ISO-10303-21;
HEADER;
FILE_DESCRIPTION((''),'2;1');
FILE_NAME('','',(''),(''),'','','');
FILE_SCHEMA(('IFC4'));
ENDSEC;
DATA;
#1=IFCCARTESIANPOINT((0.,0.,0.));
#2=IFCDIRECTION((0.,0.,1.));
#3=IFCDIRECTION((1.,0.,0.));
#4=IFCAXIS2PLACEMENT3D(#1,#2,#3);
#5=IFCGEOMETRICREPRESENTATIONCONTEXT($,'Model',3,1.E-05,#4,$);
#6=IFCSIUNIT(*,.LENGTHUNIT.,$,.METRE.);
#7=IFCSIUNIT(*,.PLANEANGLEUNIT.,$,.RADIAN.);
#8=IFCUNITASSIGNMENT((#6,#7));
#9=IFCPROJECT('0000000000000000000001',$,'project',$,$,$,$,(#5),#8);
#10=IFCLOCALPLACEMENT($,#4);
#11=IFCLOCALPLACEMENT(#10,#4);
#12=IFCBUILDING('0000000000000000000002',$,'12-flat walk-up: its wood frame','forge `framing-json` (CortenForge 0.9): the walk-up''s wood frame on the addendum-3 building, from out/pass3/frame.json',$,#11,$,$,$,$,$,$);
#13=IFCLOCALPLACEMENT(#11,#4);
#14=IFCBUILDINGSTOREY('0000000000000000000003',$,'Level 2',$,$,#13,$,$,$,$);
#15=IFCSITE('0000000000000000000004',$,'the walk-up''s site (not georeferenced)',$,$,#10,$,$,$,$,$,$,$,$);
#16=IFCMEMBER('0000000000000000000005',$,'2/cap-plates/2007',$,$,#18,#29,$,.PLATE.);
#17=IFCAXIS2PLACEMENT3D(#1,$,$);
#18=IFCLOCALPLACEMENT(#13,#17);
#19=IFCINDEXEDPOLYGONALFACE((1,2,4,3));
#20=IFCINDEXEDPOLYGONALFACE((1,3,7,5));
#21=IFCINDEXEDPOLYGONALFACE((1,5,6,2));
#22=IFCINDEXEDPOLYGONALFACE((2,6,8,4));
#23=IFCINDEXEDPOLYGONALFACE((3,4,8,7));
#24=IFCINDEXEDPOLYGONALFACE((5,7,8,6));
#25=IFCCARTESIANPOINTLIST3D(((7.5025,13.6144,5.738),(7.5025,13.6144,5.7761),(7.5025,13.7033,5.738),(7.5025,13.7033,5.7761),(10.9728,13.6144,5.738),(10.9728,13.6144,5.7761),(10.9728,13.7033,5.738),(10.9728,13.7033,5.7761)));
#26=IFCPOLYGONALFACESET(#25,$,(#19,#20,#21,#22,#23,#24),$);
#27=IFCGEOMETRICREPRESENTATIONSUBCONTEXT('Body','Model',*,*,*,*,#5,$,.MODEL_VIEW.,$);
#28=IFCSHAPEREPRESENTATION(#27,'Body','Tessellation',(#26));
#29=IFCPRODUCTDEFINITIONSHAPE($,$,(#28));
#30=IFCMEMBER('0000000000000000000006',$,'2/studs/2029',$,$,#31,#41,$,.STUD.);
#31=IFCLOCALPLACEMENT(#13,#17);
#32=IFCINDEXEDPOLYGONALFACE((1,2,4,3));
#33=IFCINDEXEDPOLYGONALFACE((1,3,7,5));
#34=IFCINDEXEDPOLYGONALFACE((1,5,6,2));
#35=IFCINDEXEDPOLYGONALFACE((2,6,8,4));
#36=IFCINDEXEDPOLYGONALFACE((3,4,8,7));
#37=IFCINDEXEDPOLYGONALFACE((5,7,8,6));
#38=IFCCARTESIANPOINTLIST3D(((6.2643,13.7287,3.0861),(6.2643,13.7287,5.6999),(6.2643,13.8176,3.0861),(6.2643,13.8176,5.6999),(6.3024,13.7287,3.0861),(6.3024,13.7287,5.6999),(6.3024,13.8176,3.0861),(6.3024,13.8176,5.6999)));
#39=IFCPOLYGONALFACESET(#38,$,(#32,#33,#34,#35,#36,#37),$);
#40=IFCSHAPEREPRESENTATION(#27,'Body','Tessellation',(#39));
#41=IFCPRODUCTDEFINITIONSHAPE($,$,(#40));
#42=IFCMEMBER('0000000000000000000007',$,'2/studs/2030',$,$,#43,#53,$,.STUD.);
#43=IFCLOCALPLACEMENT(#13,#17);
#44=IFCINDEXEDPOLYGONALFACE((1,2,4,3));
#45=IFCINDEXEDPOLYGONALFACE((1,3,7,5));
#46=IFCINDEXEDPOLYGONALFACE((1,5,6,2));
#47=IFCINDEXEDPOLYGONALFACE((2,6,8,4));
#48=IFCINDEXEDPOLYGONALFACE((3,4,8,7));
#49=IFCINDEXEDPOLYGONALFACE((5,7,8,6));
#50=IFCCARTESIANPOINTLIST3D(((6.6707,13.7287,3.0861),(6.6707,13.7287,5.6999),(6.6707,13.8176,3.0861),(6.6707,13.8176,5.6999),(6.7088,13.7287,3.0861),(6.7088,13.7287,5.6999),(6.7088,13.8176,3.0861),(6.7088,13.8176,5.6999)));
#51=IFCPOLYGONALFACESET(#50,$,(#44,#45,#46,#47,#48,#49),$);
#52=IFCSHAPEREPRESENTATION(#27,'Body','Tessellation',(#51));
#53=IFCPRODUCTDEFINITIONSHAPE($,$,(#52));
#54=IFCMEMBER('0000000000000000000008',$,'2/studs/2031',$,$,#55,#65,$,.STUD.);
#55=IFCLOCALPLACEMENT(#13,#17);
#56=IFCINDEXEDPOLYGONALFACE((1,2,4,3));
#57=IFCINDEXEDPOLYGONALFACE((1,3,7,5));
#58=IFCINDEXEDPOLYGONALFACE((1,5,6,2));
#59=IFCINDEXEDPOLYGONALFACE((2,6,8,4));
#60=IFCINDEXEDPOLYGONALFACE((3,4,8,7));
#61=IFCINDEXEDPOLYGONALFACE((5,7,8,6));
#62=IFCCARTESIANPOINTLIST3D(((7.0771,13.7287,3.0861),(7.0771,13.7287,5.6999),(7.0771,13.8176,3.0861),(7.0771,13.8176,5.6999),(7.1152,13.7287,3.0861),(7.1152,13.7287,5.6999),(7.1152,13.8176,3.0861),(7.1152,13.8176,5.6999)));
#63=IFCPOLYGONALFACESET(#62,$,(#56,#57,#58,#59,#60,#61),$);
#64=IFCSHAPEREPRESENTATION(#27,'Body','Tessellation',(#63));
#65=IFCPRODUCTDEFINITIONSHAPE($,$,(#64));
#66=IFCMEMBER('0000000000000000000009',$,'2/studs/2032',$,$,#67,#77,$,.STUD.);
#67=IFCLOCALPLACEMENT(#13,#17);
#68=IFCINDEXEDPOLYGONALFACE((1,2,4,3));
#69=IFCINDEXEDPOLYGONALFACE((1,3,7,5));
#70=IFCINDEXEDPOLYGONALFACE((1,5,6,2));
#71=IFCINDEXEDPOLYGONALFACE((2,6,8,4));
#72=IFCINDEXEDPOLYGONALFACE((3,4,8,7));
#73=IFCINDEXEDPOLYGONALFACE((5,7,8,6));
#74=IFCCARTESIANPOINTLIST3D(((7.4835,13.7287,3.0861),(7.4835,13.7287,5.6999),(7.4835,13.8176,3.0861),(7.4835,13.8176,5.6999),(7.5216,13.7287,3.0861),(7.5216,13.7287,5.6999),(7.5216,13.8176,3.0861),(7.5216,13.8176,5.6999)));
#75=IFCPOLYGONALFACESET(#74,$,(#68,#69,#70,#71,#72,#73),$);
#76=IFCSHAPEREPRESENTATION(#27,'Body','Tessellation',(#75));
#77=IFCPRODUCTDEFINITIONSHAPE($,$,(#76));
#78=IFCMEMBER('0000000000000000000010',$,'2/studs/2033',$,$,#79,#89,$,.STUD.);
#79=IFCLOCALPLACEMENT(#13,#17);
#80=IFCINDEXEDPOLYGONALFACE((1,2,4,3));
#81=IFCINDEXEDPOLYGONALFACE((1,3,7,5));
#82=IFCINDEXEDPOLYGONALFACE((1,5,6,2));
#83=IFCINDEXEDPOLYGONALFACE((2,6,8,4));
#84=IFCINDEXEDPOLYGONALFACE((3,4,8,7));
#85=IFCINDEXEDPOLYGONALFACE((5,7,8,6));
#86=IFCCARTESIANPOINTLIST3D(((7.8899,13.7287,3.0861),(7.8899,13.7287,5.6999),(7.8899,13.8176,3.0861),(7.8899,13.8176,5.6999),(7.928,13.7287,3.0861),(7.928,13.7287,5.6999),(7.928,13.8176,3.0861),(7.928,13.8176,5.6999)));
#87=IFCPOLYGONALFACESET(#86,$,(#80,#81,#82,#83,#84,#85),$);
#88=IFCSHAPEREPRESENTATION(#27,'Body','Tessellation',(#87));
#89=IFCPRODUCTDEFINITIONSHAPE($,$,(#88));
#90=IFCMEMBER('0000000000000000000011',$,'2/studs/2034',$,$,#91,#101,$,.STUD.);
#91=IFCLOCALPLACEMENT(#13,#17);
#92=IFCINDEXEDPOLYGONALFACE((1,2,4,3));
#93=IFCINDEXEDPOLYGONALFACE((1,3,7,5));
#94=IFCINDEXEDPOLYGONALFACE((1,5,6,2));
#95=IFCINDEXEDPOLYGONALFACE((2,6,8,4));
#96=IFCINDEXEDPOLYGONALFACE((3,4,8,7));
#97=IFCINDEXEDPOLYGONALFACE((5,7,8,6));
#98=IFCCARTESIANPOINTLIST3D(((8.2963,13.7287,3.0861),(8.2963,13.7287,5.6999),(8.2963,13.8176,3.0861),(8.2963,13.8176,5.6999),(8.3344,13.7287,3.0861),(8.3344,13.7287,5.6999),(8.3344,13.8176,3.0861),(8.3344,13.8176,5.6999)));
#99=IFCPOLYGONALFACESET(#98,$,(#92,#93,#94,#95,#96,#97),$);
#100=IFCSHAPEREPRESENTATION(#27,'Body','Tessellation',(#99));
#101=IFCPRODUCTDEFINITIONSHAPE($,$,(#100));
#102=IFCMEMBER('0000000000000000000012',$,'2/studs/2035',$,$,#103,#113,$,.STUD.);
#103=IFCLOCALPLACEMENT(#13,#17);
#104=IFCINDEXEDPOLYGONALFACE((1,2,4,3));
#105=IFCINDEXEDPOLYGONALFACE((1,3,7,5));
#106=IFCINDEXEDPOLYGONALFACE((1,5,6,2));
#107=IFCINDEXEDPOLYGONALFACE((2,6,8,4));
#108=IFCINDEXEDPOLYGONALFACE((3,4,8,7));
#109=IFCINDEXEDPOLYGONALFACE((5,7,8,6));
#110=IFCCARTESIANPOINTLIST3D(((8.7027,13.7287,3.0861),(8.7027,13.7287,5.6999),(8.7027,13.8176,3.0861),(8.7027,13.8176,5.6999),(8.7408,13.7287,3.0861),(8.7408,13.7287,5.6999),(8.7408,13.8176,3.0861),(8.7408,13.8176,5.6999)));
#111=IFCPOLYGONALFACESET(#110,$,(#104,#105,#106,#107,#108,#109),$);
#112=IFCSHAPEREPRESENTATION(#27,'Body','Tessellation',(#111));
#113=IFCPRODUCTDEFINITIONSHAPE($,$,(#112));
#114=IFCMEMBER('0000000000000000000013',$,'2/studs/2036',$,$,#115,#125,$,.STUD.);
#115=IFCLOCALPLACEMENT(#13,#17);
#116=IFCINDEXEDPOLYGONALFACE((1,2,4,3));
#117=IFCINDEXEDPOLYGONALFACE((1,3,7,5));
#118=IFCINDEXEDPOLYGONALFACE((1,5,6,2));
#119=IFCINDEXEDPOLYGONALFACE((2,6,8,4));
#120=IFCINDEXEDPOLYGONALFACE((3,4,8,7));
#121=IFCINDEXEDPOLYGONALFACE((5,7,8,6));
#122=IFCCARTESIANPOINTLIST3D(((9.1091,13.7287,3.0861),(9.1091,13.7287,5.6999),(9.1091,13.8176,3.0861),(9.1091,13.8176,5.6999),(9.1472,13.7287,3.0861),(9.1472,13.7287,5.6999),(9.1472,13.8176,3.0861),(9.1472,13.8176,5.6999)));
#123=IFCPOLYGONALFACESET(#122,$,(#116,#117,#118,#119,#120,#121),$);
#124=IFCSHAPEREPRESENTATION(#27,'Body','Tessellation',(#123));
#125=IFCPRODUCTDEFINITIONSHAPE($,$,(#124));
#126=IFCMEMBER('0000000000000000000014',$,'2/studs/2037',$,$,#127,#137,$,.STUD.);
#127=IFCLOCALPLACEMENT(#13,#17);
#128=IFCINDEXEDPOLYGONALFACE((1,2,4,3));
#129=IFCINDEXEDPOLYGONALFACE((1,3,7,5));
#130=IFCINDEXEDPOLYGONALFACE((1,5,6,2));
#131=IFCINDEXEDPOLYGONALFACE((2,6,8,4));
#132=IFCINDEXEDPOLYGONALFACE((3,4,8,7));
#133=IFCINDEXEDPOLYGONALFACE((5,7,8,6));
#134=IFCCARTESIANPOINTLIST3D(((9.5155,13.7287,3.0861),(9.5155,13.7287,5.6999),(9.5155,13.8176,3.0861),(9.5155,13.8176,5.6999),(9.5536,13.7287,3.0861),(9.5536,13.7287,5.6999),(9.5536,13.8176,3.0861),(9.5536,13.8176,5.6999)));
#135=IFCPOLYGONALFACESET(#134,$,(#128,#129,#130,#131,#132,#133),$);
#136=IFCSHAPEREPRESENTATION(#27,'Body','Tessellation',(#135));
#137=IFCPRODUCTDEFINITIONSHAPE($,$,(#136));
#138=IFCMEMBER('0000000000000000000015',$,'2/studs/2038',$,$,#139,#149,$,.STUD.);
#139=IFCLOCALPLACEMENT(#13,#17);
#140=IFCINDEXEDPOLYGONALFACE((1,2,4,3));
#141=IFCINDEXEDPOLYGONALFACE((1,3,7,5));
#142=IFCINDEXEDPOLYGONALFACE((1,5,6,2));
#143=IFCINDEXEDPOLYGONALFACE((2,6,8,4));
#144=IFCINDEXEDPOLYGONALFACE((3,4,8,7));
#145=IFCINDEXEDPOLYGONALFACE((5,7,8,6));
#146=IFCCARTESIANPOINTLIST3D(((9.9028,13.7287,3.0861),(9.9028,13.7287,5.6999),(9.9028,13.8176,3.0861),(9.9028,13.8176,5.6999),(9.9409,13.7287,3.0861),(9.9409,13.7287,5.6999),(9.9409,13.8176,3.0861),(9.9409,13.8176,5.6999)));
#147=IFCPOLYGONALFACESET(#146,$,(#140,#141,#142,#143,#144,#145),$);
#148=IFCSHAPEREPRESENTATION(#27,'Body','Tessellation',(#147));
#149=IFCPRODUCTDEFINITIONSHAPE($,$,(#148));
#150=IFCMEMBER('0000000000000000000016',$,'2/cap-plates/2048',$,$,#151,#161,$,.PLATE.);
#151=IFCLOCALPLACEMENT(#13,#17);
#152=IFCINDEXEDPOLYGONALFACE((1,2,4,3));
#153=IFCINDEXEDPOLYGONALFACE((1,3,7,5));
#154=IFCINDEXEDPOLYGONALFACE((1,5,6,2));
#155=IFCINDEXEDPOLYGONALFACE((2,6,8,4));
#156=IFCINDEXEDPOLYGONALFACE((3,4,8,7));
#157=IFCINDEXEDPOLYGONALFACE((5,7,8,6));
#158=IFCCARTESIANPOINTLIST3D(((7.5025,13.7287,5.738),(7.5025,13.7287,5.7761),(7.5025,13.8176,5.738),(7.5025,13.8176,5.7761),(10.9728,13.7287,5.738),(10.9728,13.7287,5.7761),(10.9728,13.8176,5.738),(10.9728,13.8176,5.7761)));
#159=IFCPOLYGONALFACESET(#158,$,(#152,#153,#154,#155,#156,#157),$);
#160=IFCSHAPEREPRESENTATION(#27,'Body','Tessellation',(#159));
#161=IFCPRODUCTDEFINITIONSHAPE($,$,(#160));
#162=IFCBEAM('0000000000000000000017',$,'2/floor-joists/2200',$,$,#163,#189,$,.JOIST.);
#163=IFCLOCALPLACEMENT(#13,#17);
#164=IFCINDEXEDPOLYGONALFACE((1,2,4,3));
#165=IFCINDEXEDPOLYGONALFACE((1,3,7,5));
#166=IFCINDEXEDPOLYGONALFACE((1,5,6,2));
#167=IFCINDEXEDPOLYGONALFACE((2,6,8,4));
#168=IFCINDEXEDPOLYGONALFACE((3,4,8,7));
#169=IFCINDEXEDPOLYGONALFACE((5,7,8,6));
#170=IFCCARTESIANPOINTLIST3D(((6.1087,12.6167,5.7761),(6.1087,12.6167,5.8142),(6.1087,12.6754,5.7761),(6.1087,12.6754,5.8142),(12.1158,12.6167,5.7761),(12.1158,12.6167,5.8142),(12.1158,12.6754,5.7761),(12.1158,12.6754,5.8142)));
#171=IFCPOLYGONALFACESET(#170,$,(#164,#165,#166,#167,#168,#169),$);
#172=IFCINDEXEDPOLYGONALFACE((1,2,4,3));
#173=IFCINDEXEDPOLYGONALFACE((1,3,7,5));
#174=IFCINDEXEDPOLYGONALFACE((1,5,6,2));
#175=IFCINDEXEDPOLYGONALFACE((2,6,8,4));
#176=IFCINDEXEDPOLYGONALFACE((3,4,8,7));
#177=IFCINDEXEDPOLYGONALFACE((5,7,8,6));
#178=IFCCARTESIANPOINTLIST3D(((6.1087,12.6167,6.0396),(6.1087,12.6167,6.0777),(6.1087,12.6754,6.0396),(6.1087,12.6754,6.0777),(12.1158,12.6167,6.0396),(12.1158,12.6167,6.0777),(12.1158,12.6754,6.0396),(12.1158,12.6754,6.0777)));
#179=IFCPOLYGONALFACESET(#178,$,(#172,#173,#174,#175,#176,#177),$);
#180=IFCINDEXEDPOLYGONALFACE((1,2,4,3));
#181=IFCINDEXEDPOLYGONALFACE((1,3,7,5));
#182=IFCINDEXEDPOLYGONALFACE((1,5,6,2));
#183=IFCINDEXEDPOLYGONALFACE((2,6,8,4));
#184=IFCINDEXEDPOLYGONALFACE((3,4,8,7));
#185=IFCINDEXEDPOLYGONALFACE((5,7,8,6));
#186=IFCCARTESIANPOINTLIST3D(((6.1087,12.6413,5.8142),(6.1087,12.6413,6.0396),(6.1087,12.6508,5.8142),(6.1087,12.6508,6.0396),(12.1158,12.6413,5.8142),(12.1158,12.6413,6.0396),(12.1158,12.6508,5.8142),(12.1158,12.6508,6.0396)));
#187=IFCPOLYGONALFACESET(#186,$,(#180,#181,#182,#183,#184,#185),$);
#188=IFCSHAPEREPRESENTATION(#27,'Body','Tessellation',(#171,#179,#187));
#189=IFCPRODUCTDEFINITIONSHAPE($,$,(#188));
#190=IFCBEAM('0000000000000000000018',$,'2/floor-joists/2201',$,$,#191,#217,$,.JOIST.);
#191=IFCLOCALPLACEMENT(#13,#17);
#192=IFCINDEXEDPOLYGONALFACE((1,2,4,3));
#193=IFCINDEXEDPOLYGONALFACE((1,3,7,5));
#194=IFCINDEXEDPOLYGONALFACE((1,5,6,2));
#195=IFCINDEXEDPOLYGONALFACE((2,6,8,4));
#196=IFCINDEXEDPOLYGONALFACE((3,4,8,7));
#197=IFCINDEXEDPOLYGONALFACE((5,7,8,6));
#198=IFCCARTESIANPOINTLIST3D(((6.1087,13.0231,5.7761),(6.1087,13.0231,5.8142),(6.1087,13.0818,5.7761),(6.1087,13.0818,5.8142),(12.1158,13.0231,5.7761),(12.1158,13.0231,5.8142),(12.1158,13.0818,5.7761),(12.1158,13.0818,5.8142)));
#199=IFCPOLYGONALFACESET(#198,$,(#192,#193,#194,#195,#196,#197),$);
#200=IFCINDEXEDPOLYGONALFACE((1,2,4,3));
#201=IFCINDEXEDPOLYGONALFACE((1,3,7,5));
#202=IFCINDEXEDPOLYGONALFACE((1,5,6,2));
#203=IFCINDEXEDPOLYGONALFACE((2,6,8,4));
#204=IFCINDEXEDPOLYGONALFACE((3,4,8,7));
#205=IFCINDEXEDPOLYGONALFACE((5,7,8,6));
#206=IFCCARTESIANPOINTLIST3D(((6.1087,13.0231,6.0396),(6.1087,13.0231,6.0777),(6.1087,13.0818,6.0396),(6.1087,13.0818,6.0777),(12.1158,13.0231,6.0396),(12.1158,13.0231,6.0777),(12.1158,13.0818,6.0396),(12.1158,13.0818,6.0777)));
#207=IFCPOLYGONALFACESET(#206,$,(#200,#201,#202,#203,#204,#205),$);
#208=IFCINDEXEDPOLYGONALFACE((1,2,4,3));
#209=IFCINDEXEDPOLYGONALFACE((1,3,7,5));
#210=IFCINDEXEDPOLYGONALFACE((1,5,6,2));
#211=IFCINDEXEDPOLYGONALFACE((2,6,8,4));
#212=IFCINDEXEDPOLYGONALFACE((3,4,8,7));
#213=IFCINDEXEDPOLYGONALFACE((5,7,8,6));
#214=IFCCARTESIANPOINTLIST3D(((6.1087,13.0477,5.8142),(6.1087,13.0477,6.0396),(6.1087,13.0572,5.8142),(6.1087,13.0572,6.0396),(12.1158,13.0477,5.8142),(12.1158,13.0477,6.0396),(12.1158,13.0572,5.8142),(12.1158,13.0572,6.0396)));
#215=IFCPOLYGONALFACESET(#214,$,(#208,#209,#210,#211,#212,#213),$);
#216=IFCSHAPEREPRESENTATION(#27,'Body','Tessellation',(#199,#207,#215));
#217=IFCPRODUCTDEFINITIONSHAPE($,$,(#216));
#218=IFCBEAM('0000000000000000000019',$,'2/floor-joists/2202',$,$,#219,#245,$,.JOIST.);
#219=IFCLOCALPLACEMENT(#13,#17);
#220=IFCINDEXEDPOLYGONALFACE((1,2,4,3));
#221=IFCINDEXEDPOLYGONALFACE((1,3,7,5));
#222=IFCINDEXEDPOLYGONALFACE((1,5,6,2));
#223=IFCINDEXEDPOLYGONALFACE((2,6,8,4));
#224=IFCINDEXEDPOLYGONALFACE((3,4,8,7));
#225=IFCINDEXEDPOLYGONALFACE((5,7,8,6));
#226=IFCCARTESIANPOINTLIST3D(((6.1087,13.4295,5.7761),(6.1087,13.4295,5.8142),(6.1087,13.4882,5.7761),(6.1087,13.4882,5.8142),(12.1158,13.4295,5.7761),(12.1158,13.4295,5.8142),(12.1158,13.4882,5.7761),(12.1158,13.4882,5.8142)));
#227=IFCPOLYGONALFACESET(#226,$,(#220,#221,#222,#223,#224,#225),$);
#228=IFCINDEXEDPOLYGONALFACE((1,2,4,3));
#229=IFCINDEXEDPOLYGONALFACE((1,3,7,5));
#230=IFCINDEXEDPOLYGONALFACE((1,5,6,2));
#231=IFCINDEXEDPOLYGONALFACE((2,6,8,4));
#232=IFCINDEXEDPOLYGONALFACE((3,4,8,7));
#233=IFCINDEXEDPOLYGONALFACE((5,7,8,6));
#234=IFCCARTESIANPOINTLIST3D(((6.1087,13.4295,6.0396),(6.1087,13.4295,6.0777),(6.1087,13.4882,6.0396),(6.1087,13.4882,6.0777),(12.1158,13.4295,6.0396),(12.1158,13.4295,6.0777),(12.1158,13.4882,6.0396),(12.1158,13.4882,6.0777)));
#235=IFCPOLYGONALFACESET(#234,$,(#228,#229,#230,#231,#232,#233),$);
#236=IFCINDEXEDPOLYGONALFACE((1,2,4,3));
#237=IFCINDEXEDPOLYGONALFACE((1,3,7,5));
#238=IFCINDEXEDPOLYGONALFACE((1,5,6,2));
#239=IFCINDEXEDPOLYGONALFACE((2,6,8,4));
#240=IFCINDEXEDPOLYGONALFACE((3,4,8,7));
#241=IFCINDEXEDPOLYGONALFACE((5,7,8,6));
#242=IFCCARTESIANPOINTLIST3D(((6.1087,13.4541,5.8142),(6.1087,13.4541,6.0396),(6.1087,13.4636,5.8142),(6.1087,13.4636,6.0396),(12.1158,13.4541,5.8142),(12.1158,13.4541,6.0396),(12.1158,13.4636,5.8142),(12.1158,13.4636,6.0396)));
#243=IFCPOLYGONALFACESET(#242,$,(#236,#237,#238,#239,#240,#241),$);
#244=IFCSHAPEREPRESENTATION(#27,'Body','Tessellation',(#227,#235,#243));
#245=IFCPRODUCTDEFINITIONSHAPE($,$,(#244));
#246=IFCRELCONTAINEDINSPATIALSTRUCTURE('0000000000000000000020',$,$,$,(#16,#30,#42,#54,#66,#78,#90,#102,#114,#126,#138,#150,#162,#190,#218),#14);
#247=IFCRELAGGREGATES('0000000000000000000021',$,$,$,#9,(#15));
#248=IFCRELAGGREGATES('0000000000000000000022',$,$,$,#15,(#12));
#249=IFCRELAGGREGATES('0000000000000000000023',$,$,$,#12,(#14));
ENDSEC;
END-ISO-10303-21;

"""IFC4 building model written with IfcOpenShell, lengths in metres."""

from ifc_helpers import new_model, si_unit, frame, frame_2d, origin, origin_with_axes, place, context, subcontext, project, spatial, rectangle, extrude, element, save


model = new_model("IFC4")

# Units and contexts
model_context = context("Model", 3, precision=1e-05, world=origin_with_axes())
body_context = subcontext(model_context, "Body", "Model", "MODEL_VIEW")
ifc_project = project(units=[si_unit("LENGTHUNIT", "METRE"), si_unit("PLANEANGLEUNIT", "RADIAN")], contexts=[model_context])

# Site, building, storey
site_placement = place(None, origin_with_axes())
site = spatial("IfcSite", under=ifc_project, at=site_placement, Name="the walk-up's site (not georeferenced)")
building_placement = place(site_placement, origin_with_axes())
building = spatial("IfcBuilding", under=site, at=building_placement, Name="12-flat walk-up: its wood frame", Description="forge `framing-json` (CortenForge 0.9): the walk-up's wood frame on the addendum-3 building, from out/pass3/frame.json")
storey_placement = place(building_placement, origin_with_axes())
storey = spatial("IfcBuildingStorey", under=building, at=storey_placement, Name="Level 2")

# Members
member_1_placement = place(storey_placement, frame((7.5025, 13.6144, 5.738), z_axis=(0.0, 0.0, 1.0), x_axis=(1.0, 0.0, 0.0)))
element("IfcMember", 1, at=member_1_placement, inside=storey, Name="2/cap-plates/2007", PredefinedType="PLATE", context=body_context, shape_type="SweptSolid", body=[
    extrude(rectangle(XDim=3.4703, YDim=0.0889, at=frame_2d((1.7351, 0.0445))), origin(), (0.0, 0.0, 1.0), 0.0381),
])
for number, where, z_axis, x_axis, name in (
    (2, (6.2643, 13.7287, 3.0861), (0.0, 0.0, 1.0), (1.0, 0.0, 0.0), "2/studs/2029"),
    (3, (6.6707, 13.7287, 3.0861), (0.0, 0.0, 1.0), (1.0, 0.0, 0.0), "2/studs/2030"),
    (4, (7.0771, 13.7287, 3.0861), (0.0, 0.0, 1.0), (1.0, 0.0, 0.0), "2/studs/2031"),
    (5, (7.4835, 13.7287, 3.0861), (0.0, 0.0, 1.0), (1.0, 0.0, 0.0), "2/studs/2032"),
    (6, (7.8899, 13.7287, 3.0861), (0.0, 0.0, 1.0), (1.0, 0.0, 0.0), "2/studs/2033"),
    (7, (8.2963, 13.7287, 3.0861), (0.0, 0.0, 1.0), (1.0, 0.0, 0.0), "2/studs/2034"),
    (8, (8.7027, 13.7287, 3.0861), (0.0, 0.0, 1.0), (1.0, 0.0, 0.0), "2/studs/2035"),
    (9, (9.1091, 13.7287, 3.0861), (0.0, 0.0, 1.0), (1.0, 0.0, 0.0), "2/studs/2036"),
    (10, (9.5155, 13.7287, 3.0861), (0.0, 0.0, 1.0), (1.0, 0.0, 0.0), "2/studs/2037"),
    (11, (9.9028, 13.7287, 3.0861), (0.0, 0.0, 1.0), (1.0, 0.0, 0.0), "2/studs/2038"),
):
    element("IfcMember", number, at=place(storey_placement, frame(where, z_axis=z_axis, x_axis=x_axis)), inside=storey, Name=name, PredefinedType="STUD", context=body_context, shape_type="SweptSolid", body=[
        extrude(rectangle(XDim=0.0381, YDim=0.0889, at=frame_2d((0.0191, 0.0445))), origin(), (0.0, 0.0, 1.0), 2.6138),
    ])
member_2_placement = place(storey_placement, frame((7.5025, 13.7287, 5.738), z_axis=(0.0, 0.0, 1.0), x_axis=(1.0, 0.0, 0.0)))
element("IfcMember", 12, at=member_2_placement, inside=storey, Name="2/cap-plates/2048", PredefinedType="PLATE", context=body_context, shape_type="SweptSolid", body=[
    extrude(rectangle(XDim=3.4703, YDim=0.0889, at=frame_2d((1.7351, 0.0445))), origin(), (0.0, 0.0, 1.0), 0.0381),
])

# Beams
beam_1_placement = place(storey_placement, frame((6.1087, 12.6167, 5.7761), z_axis=(0.0, 0.0, 1.0), x_axis=(1.0, 0.0, 0.0)))
element("IfcBeam", 13, at=beam_1_placement, inside=storey, Name="2/floor-joists/2200", PredefinedType="JOIST", context=body_context, shape_type="SweptSolid", body=[
    extrude(rectangle(XDim=6.0071, YDim=0.0587, at=frame_2d((3.0036, 0.0294))), origin(), (0.0, 0.0, 1.0), 0.0381),
    extrude(rectangle(XDim=6.0071, YDim=0.0587, at=frame_2d((3.0036, 0.0294))), frame((0.0, 0.0, 0.2635)), (0.0, 0.0, 1.0), 0.0381),
    extrude(rectangle(XDim=6.0071, YDim=0.0095, at=frame_2d((3.0036, 0.0048))), frame((0.0, 0.0246, 0.0381)), (0.0, 0.0, 1.0), 0.2254),
])
for number, where, z_axis, x_axis, name in (
    (14, (6.1087, 13.0231, 5.7761), (0.0, 0.0, 1.0), (1.0, 0.0, 0.0), "2/floor-joists/2201"),
    (15, (6.1087, 13.4295, 5.7761), (0.0, 0.0, 1.0), (1.0, 0.0, 0.0), "2/floor-joists/2202"),
):
    element("IfcBeam", number, at=place(storey_placement, frame(where, z_axis=z_axis, x_axis=x_axis)), inside=storey, Name=name, PredefinedType="JOIST", context=body_context, shape_type="SweptSolid", body=[
        extrude(rectangle(XDim=6.0071, YDim=0.0587, at=frame_2d((3.0036, 0.0294))), origin(), (0.0, 0.0, 1.0), 0.0381),
        extrude(rectangle(XDim=6.0071, YDim=0.0587, at=frame_2d((3.0036, 0.0294))), frame((0.0, 0.0, 0.2635)), (0.0, 0.0, 1.0), 0.0381),
        extrude(rectangle(XDim=6.0071, YDim=0.0095, at=frame_2d((3.0036, 0.0048))), frame((0.0, 0.0246, 0.0381)), (0.0, 0.0, 1.0), 0.2254),
    ])

save(model, "model.ifc")
